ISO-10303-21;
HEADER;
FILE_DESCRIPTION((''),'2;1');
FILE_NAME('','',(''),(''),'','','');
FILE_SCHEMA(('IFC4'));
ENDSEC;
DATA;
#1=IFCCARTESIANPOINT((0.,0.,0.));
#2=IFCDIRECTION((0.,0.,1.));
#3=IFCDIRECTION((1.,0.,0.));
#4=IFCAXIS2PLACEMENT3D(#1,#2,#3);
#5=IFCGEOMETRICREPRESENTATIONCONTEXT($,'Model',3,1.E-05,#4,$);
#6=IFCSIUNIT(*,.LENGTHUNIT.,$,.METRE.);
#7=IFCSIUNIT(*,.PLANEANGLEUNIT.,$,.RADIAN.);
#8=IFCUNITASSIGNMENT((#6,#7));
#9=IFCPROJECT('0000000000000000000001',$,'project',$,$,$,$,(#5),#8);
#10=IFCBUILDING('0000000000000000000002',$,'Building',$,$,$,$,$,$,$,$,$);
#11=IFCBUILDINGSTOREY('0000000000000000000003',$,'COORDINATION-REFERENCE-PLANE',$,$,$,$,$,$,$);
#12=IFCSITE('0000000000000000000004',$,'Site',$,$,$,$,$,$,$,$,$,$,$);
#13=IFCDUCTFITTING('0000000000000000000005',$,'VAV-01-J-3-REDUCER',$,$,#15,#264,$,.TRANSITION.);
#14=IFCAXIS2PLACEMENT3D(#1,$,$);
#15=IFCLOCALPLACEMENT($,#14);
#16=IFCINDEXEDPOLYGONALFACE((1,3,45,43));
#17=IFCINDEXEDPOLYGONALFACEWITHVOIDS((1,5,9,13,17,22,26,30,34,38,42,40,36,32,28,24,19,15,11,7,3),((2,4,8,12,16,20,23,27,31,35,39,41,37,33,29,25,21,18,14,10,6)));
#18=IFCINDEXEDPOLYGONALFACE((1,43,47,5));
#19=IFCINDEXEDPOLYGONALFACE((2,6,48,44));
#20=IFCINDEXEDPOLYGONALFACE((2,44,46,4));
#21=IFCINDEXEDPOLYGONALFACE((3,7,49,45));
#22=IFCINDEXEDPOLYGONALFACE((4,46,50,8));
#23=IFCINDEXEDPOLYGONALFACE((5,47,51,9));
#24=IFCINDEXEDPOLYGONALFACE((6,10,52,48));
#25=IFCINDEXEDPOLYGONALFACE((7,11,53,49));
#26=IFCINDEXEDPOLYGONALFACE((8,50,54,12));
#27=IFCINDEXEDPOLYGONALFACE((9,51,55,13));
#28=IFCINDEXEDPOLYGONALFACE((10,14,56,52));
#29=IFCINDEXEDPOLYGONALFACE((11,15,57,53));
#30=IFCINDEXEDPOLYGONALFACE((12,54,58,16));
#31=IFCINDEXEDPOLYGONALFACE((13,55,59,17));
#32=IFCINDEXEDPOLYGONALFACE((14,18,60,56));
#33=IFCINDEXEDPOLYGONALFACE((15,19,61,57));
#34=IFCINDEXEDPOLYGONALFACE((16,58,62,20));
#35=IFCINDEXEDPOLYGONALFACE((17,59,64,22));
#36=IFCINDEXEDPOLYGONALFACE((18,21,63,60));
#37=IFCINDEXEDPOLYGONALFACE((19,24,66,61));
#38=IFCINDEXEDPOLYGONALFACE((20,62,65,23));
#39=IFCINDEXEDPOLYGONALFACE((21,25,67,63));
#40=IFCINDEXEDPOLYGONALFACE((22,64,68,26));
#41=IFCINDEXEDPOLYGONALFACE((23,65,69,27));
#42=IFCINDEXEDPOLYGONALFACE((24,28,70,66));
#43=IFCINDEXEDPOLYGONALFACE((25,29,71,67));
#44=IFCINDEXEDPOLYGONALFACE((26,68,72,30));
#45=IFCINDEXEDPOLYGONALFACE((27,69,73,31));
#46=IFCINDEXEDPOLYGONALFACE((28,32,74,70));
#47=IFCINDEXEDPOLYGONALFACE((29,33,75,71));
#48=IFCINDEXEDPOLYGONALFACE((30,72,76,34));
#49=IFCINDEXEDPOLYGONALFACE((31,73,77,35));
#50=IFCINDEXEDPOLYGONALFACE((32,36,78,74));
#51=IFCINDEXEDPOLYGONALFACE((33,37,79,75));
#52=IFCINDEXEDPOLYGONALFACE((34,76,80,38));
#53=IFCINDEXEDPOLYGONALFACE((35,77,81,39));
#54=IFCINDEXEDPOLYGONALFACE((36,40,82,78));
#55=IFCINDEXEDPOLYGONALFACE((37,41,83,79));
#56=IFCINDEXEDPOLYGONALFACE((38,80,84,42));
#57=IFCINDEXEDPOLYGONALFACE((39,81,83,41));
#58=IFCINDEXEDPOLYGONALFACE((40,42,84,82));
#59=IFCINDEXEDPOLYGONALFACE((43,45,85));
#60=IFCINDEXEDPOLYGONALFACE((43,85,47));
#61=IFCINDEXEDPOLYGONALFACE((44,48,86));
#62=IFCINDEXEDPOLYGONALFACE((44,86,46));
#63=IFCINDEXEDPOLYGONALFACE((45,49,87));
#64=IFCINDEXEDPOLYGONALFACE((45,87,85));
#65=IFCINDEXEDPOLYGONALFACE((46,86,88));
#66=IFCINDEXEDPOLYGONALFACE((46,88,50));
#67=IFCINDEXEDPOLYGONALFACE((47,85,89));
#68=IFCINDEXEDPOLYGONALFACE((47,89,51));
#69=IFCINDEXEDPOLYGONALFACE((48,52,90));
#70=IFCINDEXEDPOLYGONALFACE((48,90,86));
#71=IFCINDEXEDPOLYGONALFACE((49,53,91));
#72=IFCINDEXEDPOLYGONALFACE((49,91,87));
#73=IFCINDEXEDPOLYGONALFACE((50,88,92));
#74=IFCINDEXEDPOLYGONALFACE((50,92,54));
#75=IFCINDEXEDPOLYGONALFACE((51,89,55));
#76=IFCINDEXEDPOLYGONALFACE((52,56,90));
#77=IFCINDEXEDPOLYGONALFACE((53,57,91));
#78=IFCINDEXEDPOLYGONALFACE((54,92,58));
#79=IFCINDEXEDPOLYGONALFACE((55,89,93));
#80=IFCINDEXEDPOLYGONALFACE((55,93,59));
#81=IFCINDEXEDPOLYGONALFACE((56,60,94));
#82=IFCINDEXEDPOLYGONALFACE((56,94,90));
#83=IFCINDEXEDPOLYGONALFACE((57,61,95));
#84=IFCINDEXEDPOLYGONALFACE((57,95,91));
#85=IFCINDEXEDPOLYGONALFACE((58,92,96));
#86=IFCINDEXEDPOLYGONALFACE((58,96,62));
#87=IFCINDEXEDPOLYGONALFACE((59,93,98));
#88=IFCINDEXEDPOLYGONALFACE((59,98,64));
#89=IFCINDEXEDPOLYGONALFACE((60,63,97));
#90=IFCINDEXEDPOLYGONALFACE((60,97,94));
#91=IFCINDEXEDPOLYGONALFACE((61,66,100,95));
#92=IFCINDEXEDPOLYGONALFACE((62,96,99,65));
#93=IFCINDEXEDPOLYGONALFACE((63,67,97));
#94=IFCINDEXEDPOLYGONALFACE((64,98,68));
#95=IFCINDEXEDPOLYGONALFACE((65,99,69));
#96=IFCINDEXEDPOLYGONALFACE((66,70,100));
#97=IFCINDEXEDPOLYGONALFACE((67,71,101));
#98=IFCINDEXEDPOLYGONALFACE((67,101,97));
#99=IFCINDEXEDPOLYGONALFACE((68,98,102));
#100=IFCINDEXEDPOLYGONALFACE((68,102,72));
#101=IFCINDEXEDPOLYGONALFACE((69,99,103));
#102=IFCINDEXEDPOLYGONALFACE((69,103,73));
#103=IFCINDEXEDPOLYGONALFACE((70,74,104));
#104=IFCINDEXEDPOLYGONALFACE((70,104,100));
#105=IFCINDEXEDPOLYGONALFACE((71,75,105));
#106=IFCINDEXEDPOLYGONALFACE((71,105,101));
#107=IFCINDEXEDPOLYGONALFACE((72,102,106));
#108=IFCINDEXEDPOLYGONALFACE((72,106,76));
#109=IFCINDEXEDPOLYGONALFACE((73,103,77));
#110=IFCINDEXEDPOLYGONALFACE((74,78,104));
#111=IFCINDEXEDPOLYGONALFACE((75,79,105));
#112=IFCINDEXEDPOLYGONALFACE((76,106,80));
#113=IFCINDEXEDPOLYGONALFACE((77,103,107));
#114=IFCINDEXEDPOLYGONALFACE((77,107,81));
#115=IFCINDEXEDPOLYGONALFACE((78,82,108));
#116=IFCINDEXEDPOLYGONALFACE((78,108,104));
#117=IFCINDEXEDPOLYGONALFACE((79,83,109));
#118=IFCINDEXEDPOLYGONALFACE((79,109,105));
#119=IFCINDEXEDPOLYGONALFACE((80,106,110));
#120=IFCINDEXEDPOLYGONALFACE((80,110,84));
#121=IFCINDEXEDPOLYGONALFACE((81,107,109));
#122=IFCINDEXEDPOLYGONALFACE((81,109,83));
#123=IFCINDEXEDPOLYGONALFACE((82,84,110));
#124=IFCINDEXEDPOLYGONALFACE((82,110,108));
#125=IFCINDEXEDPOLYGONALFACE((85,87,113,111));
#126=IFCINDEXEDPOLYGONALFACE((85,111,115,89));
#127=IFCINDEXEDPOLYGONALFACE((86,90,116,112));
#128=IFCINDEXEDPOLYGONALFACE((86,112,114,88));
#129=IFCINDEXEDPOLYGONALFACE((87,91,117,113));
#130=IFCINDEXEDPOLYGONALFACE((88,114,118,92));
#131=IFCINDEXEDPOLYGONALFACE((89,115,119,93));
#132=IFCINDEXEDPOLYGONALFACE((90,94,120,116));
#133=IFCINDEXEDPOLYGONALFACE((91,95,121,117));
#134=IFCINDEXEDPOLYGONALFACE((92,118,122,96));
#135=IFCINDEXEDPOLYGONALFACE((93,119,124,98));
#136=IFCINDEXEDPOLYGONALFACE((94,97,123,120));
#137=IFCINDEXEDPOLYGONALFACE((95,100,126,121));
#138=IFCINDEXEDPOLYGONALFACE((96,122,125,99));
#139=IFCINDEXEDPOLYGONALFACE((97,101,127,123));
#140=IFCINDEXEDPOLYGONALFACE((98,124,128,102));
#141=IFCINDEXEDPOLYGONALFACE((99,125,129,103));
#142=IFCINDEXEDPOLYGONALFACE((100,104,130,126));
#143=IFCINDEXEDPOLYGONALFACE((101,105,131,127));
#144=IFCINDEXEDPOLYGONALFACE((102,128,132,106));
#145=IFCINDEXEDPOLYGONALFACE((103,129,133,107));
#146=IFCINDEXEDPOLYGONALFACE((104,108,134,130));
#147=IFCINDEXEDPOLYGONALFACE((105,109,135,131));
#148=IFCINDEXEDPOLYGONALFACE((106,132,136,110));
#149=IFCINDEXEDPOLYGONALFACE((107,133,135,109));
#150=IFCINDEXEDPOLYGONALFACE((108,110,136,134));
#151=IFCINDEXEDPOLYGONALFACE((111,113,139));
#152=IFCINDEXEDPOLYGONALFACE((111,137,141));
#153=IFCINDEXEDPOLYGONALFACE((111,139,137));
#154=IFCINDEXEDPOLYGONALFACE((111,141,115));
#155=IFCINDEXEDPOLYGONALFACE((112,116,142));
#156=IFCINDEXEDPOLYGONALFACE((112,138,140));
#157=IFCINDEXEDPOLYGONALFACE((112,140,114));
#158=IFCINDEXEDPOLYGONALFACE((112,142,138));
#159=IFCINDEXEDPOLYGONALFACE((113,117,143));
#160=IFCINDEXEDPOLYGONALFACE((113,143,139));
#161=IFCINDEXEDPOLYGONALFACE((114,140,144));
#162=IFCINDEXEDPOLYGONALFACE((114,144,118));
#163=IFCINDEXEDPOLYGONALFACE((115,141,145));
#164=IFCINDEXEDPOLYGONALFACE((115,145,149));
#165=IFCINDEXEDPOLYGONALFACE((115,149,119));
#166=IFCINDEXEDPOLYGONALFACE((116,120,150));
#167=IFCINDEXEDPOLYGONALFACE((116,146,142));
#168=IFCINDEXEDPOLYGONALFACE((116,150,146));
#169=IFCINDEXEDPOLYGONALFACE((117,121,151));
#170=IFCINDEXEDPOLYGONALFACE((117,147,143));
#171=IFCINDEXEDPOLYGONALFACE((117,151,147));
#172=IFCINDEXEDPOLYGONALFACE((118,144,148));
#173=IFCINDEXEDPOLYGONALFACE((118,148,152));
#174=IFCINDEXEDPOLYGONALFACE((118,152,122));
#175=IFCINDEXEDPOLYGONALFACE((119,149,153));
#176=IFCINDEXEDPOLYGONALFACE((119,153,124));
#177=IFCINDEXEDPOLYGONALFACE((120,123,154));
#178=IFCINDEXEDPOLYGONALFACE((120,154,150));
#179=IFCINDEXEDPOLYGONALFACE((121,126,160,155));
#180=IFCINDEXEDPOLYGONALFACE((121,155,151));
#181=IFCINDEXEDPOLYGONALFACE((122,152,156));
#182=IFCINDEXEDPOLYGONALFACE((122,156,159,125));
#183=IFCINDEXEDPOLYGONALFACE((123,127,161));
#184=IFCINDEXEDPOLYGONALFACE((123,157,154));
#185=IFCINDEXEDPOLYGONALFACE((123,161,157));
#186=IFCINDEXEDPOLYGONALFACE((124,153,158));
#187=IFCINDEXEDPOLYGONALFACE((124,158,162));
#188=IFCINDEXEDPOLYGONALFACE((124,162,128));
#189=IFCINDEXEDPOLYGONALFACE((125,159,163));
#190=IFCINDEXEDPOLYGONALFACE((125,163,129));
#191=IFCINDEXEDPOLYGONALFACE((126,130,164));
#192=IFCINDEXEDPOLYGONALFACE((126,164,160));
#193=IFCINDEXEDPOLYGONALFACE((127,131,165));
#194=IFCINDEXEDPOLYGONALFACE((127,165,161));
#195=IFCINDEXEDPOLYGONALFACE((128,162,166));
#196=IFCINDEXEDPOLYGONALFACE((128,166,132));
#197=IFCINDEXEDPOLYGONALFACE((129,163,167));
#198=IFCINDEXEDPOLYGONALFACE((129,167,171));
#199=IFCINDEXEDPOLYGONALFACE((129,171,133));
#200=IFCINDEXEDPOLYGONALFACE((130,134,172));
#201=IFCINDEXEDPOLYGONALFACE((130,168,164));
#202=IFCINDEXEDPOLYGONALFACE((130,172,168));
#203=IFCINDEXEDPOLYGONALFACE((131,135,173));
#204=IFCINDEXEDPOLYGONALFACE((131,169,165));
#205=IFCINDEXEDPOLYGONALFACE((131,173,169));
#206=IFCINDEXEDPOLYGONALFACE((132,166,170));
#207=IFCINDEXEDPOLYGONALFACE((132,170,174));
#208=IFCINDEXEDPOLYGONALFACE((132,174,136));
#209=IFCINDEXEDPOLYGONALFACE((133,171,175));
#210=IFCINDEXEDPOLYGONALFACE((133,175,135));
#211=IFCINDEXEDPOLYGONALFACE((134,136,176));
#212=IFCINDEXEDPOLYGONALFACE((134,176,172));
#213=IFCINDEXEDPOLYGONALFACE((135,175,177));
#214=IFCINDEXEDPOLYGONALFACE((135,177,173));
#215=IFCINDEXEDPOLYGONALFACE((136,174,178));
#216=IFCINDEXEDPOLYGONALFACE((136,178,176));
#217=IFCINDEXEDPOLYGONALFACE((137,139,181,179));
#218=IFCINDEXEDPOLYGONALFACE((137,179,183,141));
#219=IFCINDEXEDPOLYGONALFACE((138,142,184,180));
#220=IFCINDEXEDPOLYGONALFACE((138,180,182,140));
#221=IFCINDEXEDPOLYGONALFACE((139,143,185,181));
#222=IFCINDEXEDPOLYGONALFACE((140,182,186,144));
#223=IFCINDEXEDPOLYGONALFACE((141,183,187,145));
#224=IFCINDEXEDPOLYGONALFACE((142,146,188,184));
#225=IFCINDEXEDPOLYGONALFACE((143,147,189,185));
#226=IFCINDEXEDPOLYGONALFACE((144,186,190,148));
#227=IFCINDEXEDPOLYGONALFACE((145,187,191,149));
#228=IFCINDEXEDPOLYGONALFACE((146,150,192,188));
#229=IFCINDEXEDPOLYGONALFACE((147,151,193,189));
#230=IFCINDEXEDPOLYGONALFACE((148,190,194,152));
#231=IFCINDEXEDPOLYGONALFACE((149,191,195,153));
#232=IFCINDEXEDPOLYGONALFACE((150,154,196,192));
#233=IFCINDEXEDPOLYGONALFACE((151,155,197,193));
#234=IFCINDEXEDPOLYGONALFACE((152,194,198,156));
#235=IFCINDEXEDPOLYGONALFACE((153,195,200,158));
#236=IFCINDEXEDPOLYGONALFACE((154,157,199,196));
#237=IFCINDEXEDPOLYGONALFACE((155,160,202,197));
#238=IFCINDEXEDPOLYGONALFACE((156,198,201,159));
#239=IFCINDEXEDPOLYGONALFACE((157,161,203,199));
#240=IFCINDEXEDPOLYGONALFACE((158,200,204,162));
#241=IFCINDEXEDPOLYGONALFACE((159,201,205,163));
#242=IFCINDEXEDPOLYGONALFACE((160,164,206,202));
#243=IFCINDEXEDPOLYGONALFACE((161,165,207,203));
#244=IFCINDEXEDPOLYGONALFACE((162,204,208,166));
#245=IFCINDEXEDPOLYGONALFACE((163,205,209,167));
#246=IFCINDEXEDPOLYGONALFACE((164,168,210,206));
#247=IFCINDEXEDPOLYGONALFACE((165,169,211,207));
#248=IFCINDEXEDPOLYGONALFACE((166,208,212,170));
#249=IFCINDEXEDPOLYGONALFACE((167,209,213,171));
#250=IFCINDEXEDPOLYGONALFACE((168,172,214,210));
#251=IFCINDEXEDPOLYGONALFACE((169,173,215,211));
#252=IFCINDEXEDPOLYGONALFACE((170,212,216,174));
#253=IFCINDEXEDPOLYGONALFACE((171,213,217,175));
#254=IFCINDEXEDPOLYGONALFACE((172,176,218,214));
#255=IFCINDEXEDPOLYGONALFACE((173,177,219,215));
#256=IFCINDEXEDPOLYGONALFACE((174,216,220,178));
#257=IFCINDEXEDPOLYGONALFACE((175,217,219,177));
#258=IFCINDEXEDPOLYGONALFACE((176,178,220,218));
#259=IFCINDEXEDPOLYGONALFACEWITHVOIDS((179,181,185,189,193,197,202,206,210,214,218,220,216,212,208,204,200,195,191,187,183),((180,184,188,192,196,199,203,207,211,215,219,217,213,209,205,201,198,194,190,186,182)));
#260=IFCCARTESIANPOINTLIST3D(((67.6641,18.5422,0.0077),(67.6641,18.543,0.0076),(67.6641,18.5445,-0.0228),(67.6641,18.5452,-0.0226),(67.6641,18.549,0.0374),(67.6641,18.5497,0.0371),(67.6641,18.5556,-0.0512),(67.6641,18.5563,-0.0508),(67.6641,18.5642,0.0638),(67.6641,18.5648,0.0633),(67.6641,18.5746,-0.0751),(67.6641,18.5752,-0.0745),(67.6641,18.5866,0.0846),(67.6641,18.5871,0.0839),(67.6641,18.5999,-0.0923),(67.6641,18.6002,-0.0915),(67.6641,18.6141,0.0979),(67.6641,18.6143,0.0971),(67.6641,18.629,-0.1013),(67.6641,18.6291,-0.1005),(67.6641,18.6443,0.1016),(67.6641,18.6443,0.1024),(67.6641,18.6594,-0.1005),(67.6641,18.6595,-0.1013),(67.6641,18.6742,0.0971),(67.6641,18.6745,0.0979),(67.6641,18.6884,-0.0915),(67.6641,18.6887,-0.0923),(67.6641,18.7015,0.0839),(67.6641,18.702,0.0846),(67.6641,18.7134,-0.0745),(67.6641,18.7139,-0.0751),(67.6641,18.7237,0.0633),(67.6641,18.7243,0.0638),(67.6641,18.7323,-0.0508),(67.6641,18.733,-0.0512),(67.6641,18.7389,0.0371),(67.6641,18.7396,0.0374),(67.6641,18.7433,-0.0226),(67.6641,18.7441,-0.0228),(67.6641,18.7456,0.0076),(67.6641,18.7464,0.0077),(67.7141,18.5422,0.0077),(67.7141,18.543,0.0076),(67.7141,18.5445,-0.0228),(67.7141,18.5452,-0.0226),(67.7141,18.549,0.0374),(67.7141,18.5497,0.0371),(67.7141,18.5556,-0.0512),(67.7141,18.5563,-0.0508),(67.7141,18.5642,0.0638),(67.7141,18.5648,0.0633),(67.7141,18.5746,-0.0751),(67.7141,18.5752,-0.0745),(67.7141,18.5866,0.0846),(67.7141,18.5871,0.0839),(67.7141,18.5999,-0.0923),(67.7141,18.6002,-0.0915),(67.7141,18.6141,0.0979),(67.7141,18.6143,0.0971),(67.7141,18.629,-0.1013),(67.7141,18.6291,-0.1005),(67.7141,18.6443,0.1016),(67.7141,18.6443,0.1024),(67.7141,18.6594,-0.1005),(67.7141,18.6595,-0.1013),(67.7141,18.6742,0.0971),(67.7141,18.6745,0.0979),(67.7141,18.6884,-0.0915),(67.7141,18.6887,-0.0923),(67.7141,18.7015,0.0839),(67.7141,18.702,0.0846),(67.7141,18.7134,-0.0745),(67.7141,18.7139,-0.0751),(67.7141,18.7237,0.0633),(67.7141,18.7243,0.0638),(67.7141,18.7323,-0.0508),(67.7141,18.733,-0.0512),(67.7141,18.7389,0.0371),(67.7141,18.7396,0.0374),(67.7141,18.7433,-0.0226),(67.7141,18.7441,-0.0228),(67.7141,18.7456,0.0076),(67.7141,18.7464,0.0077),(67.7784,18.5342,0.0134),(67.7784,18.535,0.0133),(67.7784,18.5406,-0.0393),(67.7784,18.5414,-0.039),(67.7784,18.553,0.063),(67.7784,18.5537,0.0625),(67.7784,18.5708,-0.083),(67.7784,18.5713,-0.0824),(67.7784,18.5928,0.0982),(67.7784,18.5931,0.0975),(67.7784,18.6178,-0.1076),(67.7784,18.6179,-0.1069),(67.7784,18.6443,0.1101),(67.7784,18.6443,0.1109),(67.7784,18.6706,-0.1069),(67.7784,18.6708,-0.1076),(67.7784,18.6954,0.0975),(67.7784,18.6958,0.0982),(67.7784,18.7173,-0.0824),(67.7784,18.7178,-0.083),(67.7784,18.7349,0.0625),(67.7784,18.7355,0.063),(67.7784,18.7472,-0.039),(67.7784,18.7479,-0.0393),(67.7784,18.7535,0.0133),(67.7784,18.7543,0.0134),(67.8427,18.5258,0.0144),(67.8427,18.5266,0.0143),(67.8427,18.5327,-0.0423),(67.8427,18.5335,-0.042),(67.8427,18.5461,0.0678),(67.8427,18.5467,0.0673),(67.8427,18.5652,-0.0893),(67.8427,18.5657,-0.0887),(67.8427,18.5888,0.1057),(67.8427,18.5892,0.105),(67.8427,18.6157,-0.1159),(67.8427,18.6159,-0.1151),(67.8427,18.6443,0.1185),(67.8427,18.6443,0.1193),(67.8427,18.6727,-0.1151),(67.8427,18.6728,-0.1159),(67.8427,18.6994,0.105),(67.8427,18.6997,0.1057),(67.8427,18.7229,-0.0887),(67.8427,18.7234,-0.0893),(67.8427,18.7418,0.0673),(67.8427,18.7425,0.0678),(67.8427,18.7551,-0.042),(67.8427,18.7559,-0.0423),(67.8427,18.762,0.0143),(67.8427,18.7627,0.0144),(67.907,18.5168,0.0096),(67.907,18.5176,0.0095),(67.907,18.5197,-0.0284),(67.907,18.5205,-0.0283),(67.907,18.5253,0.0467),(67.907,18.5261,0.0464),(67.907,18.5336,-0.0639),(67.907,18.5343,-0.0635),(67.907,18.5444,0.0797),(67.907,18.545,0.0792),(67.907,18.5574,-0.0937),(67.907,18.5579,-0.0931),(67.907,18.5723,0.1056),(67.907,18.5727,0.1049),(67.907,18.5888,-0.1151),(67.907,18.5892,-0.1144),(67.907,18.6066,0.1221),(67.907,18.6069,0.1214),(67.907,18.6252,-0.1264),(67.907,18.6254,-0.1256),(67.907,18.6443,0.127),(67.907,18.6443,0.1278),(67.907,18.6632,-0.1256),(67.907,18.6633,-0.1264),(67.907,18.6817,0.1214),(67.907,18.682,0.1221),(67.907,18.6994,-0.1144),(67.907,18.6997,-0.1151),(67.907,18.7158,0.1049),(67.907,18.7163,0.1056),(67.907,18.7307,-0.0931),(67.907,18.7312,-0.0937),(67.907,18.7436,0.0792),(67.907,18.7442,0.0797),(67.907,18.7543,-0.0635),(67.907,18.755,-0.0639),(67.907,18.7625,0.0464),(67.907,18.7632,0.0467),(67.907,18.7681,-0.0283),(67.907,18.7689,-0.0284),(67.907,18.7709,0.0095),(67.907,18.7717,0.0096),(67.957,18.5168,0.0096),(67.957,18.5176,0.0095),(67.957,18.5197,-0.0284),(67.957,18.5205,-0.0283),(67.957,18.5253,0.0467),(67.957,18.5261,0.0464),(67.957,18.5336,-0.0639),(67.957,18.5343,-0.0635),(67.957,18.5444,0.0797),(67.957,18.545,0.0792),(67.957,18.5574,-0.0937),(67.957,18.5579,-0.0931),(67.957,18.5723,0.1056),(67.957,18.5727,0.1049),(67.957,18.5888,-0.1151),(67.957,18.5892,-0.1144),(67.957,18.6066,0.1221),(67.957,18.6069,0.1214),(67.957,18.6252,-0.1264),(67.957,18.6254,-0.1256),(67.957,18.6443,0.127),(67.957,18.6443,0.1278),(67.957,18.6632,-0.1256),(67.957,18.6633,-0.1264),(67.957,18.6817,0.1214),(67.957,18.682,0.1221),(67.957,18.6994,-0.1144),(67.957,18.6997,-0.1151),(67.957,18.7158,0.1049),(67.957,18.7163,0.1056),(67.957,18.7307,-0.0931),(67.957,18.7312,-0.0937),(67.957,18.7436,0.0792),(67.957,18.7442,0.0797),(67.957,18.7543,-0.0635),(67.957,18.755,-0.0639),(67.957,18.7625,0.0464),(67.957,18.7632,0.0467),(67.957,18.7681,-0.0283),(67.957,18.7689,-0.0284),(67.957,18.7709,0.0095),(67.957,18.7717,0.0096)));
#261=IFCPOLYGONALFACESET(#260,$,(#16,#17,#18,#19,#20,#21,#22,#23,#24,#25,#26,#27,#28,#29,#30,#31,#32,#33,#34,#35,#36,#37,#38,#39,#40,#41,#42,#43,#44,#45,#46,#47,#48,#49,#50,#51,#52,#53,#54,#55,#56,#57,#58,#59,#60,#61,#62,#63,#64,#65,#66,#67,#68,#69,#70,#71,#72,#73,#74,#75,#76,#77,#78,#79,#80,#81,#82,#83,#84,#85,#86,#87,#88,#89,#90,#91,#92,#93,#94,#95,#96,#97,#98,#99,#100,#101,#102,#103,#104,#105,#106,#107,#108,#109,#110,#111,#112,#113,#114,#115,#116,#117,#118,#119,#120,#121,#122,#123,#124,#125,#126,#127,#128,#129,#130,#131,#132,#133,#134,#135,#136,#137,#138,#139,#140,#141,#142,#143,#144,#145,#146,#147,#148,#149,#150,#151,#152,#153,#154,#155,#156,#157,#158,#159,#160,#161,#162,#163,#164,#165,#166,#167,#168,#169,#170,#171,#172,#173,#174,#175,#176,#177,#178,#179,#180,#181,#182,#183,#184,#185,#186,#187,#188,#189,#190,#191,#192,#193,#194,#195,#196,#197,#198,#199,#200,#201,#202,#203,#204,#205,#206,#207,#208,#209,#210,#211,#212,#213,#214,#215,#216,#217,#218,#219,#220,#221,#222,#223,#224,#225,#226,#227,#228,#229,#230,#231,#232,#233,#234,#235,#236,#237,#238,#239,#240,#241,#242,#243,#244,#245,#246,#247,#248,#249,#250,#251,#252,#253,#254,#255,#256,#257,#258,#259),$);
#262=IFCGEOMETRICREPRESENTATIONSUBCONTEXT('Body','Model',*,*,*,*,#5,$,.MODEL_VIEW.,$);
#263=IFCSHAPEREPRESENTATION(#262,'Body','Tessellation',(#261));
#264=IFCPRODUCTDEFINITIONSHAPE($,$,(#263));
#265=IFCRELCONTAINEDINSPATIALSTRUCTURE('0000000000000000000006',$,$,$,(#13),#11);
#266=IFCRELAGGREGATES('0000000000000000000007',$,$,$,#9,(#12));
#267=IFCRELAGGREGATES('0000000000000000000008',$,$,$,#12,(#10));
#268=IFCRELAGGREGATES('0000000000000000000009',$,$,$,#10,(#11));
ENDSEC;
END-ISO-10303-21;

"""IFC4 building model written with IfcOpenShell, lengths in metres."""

from ifc_helpers import new_model, entity, si_unit, frame, origin_with_axes, place, context, subcontext, project, spatial, element, save


model = new_model("IFC4")

# Units and contexts
model_context = context("Model", 3, precision=1e-05, world=origin_with_axes())
body_context_1 = subcontext(model_context, "Body", "Model", "MODEL_VIEW")
ifc_project = project(units=[si_unit("LENGTHUNIT", "METRE"), si_unit("PLANEANGLEUNIT", "RADIAN")], contexts=[model_context])

# Site, building, storey
site = spatial("IfcSite", under=ifc_project, Name="Site")
building = spatial("IfcBuilding", under=site, Name="Building")
storey = spatial("IfcBuildingStorey", under=building, Name="COORDINATION-REFERENCE-PLANE")

# Duct fitting
for number, where, z_axis, x_axis, name in (
    (1, (67.957, 18.6443, 0.0), (0.0, -1.0, 0.0), (0.0, 0.0, 1.0), "VAV-01-J-3-REDUCER"),
):
    element("IfcDuctFitting", number, at=place(None, frame(where, z_axis=z_axis, x_axis=x_axis)), inside=storey, Name=name, PredefinedType="TRANSITION", context=body_context_1, shape_type="SweptSolid", body=[
        entity("IfcRevolvedAreaSolid", entity("IfcArbitraryClosedProfileDef", "AREA", None, entity("IfcPolyline", [entity("IfcCartesianPoint", [0.1278, 0.0]), entity("IfcCartesianPoint", [0.1278, 0.05]), entity("IfcCartesianPoint", [0.1024, 0.2429]), entity("IfcCartesianPoint", [0.1024, 0.2929]), entity("IfcCartesianPoint", [0.1016, 0.2929]), entity("IfcCartesianPoint", [0.1016, 0.2429]), entity("IfcCartesianPoint", [0.127, 0.05]), entity("IfcCartesianPoint", [0.127, 0.0]), entity("IfcCartesianPoint", [0.1278, 0.0])])), entity("IfcAxis2Placement3D", entity("IfcCartesianPoint", [0.0, 0.0, 0.0])), entity("IfcAxis1Placement", entity("IfcCartesianPoint", [0.0, 0.0, 0.0]), entity("IfcDirection", [0.0, 1.0, 0.0])), 6.283185),
    ])

save(model, "model.ifc")
